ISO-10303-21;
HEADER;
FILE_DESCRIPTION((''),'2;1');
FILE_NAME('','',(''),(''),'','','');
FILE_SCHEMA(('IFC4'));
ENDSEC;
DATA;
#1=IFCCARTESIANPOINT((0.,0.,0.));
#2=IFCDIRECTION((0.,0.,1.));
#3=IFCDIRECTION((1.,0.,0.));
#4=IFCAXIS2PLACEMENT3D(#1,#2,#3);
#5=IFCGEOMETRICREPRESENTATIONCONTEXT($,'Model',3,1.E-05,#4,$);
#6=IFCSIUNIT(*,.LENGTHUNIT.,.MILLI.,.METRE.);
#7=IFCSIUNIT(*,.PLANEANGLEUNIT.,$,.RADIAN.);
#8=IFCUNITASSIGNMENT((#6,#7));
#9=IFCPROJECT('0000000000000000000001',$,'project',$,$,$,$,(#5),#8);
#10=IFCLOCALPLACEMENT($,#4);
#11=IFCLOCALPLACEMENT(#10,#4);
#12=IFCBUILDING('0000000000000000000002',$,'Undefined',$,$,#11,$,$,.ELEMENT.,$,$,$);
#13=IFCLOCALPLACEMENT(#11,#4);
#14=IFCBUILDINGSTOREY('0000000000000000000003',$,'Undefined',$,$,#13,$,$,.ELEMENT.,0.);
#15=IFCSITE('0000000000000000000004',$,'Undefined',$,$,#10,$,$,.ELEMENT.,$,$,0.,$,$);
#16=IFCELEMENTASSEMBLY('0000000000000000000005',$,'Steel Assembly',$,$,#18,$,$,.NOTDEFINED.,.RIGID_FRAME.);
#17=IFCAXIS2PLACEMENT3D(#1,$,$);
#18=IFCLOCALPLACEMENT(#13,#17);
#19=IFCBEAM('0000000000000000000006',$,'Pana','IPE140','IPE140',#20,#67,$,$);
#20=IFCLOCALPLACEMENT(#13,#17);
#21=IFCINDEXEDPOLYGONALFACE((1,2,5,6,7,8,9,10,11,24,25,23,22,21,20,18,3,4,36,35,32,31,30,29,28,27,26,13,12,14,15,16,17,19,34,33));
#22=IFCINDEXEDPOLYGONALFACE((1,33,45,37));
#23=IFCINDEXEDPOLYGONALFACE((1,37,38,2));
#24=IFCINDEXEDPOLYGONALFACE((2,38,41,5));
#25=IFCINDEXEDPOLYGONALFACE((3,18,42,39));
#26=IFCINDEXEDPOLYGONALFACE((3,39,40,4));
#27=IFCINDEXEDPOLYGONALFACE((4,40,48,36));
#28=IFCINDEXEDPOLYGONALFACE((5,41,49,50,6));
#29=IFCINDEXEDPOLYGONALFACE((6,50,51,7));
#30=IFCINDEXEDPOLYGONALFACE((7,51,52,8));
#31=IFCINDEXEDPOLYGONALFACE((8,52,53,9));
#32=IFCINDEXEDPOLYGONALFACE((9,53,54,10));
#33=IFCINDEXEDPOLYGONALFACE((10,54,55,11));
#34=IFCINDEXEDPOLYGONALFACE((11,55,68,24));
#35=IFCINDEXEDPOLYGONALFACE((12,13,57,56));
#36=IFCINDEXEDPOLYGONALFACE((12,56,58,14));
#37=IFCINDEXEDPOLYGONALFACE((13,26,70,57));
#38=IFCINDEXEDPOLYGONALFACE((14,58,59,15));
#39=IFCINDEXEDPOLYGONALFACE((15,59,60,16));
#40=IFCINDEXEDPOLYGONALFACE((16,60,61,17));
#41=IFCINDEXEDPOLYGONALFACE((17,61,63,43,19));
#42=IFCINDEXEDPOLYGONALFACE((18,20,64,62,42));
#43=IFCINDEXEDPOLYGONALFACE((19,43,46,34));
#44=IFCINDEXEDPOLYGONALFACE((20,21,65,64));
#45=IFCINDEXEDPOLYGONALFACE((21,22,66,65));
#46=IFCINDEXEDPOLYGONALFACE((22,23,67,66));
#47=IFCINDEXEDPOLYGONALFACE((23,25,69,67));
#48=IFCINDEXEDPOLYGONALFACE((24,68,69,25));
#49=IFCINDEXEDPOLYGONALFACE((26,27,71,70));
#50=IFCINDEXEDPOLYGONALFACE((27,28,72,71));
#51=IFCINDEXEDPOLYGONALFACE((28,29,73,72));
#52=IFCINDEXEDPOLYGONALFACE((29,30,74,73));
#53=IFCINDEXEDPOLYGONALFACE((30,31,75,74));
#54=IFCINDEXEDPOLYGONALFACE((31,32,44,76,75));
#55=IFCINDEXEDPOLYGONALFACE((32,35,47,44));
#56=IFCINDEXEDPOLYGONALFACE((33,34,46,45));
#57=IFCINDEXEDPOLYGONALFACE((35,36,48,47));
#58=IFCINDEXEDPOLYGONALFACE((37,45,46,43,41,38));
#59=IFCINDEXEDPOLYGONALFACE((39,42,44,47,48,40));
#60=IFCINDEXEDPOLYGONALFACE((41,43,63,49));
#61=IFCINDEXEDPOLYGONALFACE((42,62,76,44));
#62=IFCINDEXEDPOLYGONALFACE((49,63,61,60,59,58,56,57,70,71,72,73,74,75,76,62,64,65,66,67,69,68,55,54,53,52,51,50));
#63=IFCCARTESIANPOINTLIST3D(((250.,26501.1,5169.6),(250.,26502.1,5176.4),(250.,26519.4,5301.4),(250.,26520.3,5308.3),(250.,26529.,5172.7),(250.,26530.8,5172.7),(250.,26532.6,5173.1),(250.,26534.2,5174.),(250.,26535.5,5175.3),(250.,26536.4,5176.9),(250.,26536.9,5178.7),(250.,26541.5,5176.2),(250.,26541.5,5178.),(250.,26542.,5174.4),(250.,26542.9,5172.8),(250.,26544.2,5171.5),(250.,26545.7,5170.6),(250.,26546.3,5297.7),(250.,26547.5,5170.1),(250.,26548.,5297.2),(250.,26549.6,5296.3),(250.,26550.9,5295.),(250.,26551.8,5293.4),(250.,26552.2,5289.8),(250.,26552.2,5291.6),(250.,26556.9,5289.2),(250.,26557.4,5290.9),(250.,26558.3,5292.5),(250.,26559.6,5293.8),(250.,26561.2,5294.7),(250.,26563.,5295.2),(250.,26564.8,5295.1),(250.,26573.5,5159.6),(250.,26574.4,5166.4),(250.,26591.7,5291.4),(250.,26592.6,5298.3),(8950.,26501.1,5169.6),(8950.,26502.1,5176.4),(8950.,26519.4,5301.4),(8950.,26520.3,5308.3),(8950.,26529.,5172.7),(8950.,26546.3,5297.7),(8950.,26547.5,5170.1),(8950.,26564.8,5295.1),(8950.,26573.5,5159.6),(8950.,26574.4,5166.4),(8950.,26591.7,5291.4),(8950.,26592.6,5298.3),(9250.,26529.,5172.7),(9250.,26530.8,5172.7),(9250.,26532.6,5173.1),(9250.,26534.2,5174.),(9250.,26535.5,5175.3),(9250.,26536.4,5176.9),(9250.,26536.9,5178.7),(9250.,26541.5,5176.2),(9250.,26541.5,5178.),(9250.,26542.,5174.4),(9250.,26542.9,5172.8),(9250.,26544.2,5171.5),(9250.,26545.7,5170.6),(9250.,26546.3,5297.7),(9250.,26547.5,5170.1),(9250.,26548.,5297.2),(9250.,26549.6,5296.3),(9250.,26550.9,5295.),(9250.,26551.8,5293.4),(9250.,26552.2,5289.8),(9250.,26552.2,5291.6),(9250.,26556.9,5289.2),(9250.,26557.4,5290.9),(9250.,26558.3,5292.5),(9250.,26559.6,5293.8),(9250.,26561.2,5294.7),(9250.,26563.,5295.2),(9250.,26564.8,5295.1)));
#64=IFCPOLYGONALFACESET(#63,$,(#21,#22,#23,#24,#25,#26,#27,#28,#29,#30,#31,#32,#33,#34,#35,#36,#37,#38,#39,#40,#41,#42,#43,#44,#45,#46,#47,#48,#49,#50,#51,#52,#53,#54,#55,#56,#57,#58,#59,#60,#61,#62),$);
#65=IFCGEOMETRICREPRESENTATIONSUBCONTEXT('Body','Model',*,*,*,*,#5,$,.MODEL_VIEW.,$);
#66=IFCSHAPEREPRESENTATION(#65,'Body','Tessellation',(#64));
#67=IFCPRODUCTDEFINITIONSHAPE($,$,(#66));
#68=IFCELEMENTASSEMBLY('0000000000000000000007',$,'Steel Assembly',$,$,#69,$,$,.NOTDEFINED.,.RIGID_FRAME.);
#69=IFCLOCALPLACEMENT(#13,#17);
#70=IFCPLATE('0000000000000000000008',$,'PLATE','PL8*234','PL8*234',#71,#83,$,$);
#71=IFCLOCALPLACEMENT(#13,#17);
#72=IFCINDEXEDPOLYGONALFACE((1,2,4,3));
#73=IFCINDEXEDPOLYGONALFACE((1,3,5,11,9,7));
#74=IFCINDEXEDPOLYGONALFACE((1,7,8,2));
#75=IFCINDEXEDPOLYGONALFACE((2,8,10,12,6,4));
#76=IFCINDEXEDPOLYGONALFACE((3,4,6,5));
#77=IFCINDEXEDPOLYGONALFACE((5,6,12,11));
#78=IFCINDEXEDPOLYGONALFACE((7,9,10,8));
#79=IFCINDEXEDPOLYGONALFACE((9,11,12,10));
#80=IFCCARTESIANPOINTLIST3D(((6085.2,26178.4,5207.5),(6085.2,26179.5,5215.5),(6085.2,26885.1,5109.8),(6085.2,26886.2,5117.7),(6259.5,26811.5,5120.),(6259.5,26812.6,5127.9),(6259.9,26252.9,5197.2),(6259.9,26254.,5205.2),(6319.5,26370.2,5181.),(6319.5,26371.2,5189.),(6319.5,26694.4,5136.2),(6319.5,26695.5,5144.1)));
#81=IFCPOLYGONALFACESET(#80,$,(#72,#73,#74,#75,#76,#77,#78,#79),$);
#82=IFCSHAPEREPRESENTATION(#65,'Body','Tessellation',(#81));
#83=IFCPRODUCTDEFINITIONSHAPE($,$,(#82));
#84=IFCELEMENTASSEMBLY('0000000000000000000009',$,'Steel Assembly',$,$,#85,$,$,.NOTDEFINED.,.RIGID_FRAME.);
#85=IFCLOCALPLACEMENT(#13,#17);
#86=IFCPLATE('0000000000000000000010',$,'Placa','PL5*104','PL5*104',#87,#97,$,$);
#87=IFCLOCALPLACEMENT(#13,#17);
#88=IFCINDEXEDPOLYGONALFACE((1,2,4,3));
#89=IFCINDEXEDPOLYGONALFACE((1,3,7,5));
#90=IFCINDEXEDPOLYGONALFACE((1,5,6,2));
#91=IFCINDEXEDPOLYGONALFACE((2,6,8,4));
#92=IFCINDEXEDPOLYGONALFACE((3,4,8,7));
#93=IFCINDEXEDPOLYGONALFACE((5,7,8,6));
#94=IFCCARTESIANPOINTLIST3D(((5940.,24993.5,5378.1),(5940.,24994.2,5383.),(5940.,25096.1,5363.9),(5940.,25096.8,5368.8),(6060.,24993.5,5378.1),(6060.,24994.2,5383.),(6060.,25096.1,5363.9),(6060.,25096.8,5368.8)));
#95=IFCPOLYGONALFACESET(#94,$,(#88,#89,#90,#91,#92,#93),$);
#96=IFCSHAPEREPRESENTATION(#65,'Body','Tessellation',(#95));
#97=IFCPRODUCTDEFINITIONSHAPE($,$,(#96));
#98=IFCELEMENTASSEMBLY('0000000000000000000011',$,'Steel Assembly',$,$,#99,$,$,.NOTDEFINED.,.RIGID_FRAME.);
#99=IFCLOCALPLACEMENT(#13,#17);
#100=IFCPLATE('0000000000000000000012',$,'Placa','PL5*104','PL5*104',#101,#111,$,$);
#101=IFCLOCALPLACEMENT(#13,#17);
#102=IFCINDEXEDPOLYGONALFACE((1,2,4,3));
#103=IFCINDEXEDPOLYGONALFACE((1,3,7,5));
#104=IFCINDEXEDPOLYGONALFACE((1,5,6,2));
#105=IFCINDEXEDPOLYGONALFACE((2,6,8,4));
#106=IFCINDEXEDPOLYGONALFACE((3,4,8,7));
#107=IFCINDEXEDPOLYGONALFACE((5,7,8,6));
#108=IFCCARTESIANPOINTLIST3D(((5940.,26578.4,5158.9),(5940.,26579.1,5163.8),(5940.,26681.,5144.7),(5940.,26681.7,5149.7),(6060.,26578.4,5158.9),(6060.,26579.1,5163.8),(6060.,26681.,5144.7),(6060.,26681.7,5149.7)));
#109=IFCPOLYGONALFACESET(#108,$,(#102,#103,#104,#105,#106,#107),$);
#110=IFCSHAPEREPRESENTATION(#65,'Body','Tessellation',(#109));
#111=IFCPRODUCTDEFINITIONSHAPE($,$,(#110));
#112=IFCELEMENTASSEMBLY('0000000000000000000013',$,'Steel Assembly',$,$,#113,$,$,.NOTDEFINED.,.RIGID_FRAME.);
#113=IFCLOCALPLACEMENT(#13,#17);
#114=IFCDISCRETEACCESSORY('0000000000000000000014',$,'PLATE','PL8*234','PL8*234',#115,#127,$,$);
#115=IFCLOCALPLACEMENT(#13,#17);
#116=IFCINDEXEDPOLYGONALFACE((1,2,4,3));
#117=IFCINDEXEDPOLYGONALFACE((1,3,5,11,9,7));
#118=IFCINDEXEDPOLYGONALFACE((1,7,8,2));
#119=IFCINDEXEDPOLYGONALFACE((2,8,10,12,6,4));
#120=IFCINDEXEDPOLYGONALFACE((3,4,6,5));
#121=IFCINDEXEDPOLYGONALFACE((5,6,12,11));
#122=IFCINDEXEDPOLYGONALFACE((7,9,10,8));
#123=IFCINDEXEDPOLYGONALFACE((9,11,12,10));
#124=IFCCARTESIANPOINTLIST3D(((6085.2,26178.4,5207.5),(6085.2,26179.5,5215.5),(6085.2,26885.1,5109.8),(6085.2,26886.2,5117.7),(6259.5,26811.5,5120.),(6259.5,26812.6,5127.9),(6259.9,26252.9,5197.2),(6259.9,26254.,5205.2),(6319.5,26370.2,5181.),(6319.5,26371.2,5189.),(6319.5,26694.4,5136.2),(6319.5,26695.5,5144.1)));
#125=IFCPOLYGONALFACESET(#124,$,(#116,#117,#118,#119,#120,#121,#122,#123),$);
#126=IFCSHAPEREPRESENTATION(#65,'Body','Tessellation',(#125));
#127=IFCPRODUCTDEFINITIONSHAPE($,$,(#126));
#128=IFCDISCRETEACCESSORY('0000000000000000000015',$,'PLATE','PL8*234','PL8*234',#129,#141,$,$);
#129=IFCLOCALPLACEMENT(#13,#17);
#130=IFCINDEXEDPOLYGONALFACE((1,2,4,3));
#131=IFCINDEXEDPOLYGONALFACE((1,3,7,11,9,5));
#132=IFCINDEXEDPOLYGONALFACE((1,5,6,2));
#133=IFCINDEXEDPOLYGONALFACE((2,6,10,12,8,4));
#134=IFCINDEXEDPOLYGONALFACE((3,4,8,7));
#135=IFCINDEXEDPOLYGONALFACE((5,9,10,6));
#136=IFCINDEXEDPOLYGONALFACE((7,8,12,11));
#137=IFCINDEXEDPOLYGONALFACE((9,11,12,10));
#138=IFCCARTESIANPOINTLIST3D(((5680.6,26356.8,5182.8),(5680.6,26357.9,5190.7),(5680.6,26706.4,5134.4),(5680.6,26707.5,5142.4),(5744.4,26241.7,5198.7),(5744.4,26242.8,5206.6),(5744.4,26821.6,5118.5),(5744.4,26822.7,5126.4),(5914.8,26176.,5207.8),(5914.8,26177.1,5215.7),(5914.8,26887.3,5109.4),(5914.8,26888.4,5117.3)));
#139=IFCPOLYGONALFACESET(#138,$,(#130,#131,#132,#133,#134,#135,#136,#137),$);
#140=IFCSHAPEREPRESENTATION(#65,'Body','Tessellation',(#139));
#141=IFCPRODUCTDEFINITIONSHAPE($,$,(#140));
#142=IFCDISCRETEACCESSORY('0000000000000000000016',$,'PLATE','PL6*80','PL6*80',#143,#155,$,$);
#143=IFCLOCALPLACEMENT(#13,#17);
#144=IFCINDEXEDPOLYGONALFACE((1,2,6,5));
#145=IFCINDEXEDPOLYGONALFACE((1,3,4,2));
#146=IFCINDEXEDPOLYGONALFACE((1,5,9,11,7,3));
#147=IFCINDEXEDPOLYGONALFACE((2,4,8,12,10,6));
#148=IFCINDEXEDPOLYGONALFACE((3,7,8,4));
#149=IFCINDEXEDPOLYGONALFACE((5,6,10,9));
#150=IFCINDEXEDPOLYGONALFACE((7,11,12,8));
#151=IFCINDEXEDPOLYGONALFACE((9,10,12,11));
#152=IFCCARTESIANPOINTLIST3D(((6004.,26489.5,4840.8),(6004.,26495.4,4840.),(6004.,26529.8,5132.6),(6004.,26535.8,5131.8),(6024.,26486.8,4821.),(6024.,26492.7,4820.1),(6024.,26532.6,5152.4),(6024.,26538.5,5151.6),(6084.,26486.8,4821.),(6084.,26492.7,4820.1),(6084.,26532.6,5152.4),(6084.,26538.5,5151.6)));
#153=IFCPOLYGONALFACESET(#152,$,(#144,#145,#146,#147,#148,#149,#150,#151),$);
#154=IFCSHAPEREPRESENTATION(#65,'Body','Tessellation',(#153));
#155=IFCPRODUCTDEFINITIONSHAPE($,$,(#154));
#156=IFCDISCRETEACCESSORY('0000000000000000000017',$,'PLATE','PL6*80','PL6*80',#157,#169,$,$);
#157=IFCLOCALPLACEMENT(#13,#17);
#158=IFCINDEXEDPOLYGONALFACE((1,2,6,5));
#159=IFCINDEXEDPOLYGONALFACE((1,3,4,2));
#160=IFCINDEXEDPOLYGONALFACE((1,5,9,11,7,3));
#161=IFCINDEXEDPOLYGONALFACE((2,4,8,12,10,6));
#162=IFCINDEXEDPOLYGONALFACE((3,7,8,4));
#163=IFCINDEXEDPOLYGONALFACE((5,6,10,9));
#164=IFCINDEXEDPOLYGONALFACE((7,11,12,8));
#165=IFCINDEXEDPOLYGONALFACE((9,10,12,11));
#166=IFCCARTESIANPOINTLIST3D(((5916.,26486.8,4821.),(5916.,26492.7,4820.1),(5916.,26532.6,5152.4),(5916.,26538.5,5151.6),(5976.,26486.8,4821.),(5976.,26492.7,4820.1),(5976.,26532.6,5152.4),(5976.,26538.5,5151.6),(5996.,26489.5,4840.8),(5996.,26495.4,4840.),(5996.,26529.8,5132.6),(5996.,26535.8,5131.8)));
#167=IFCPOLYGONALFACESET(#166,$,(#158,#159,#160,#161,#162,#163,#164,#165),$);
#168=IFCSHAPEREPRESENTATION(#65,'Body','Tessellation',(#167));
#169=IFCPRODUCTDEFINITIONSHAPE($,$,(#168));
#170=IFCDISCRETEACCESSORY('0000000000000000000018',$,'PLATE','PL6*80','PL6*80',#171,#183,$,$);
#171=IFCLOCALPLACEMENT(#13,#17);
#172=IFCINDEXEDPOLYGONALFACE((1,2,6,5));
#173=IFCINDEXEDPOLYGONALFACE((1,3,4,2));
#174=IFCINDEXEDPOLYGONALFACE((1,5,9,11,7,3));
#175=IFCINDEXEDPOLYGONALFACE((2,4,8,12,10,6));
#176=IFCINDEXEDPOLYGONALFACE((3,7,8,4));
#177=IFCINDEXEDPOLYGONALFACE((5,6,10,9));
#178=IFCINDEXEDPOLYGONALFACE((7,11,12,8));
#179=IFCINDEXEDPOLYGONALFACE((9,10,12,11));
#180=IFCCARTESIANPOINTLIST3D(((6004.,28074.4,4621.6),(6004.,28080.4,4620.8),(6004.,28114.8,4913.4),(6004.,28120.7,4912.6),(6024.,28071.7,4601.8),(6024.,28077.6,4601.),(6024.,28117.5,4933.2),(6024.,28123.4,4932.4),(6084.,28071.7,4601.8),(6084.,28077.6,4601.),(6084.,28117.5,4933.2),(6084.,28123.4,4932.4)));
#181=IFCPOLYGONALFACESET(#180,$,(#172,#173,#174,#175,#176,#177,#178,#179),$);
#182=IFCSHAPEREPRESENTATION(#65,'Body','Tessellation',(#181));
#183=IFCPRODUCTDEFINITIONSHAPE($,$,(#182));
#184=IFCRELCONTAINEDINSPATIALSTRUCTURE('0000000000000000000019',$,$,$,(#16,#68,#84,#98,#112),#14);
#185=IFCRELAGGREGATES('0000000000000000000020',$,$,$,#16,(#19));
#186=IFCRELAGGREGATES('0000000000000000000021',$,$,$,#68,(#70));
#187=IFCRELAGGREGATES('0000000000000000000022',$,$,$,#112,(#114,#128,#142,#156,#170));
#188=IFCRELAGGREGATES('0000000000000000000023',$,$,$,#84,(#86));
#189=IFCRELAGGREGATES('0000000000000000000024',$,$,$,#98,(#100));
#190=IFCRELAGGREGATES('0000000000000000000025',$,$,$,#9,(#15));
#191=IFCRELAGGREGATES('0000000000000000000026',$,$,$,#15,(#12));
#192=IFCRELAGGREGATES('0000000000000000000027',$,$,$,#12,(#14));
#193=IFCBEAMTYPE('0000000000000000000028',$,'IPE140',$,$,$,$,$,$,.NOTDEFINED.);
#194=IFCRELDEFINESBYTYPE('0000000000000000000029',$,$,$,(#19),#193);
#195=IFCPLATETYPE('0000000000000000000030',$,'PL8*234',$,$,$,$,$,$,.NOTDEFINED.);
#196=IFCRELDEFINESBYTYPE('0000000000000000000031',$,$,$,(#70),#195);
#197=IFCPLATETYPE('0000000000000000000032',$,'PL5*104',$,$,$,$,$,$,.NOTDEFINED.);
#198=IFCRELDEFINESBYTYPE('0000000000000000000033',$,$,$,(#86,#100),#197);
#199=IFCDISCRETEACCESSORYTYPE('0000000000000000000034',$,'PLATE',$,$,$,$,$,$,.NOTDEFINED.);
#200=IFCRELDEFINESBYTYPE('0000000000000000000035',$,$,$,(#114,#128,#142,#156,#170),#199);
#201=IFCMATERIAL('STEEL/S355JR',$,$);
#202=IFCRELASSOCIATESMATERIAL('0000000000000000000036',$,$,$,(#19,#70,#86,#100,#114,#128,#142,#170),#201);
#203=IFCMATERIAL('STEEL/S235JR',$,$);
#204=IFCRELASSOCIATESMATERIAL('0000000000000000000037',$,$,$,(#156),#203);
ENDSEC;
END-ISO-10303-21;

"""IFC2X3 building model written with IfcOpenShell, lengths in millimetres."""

from ifc_helpers import new_model, si_unit, frame, origin_with_axes, origin_2d_with_axis, place, context, subcontext, project, spatial, polyline, i_section, outline, extrude, boolean, halfspace, material, type_object, element, aggregate, save


model = new_model("IFC2X3")

# Units and contexts
model_context = context("Model", 3, precision=1e-05, world=origin_with_axes())
body_context = subcontext(model_context, "Body", "Model", "MODEL_VIEW")
ifc_project = project(units=[si_unit("LENGTHUNIT", "METRE", prefix="MILLI"), si_unit("PLANEANGLEUNIT", "RADIAN")], contexts=[model_context])

# Site, building, storey
site_placement = place(None, origin_with_axes())
site = spatial("IfcSite", under=ifc_project, at=site_placement, Name="Undefined", CompositionType="ELEMENT", RefElevation=0.0)
building_placement = place(site_placement, origin_with_axes())
building = spatial("IfcBuilding", under=site, at=building_placement, Name="Undefined", CompositionType="ELEMENT")
storey_placement = place(building_placement, origin_with_axes())
storey = spatial("IfcBuildingStorey", under=building, at=storey_placement, Name="Undefined", CompositionType="ELEMENT", Elevation=0.0)

# Element assembly, beam
ifc_material_1 = material(Name="STEEL/S355JR")
beam_type_1 = type_object("IfcBeamType", Name="IPE140", PredefinedType="NOTDEFINED")
assembly_1_placement = place(storey_placement, origin_with_axes())
assembly_1 = element("IfcElementAssembly", 1, at=assembly_1_placement, inside=storey, Name="Steel Assembly", AssemblyPlace="NOTDEFINED", PredefinedType="RIGID_FRAME")
beam_1_placement = place(assembly_1_placement, frame((9250.0, 26546.9, 5233.9), z_axis=(0.0, 0.136926, 0.990581), x_axis=(-1.0, 0.0, 0.0)))
beam_1 = element("IfcBeam", 2, at=beam_1_placement, type_object=beam_type_1, material=ifc_material_1, Name="Pana", Description="IPE140", ObjectType="IPE140", context=body_context, shape_type="CSG", body=[
    boolean("DIFFERENCE", boolean("DIFFERENCE", extrude(i_section(OverallWidth=73.0, OverallDepth=140.0, WebThickness=4.7, FlangeThickness=6.9, FilletRadius=7.0, at=origin_2d_with_axis()), frame((9000.0, 0.0, 0.0), z_axis=(-1.0, 0.0, 0.0), x_axis=(0.0, -1.0, 0.0)), (0.0, 0.0, 1.0), 9005.0), extrude(outline(polyline([(0.0, 0.0), (11.9, 0.0), (11.9, 300.0), (138.1, 300.0), (138.1, 0.0), (150.0, 0.0), (150.0, 305.0), (0.0, 305.0), (0.0, 0.0)])), frame((300.0, -41.5, 75.0), z_axis=(0.0, 1.0, 0.0), x_axis=(0.0, 0.0, -1.0)), (0.0, 0.0, 1.0), 83.0)), halfspace(frame((-5.0, 0.0, 1070.0), z_axis=(1.0, 0.0, 0.0), x_axis=(0.0, 0.0, -1.0)), True)),
])
aggregate(assembly_1, [beam_1])

# Element assemblies, plates
assembly_2_placement = place(storey_placement, origin_with_axes())
assembly_2 = element("IfcElementAssembly", 3, at=assembly_2_placement, inside=storey, Name="Steel Assembly", AssemblyPlace="NOTDEFINED", PredefinedType="RIGID_FRAME")
plate_type_1 = type_object("IfcPlateType", Name="PL8*234", PredefinedType="NOTDEFINED")
plate_1_placement = place(assembly_2_placement, frame((6085.2, 26885.7, 5113.8), z_axis=(-0.000018, 0.13698, 0.990574), x_axis=(0.0, -0.990574, 0.13698)))
plate_1 = element("IfcPlate", 4, at=plate_1_placement, type_object=plate_type_1, material=ifc_material_1, Name="PLATE", Description="PL8*234", ObjectType="PL8*234", context=body_context, shape_type="SweptSolid", body=[
    extrude(outline(polyline([(0.0, 0.0), (713.5, 0.0), (638.3, 174.6), (519.9, 234.3), (192.5, 234.3), (74.3, 174.2), (0.0, 0.0)])), frame((0.0, 0.0, -4.0), z_axis=(0.0, 0.0, 1.0), x_axis=(1.0, 0.0, 0.0)), (0.0, 0.0, 1.0), 8.0),
])
aggregate(assembly_2, [plate_1])
assembly_3_placement = place(storey_placement, origin_with_axes())
assembly_3 = element("IfcElementAssembly", 5, at=assembly_3_placement, inside=storey, Name="Steel Assembly", AssemblyPlace="NOTDEFINED", PredefinedType="RIGID_FRAME")
plate_type_2 = type_object("IfcPlateType", Name="PL5*104", PredefinedType="NOTDEFINED")
plate_2_placement = place(assembly_3_placement, frame((5940.0, 24993.8, 5380.5), z_axis=(0.0, -0.136905, -0.990584), x_axis=(0.0, 0.990584, -0.136905)))
plate_2 = element("IfcPlate", 6, at=plate_2_placement, type_object=plate_type_2, material=ifc_material_1, Name="Placa", Description="PL5*104", ObjectType="PL5*104", context=body_context, shape_type="SweptSolid", body=[
    extrude(outline(polyline([(0.0, 0.0), (103.6, 0.0), (103.6, 120.0), (0.0, 120.0), (0.0, 0.0)])), frame((0.0, 0.0, -2.5), z_axis=(0.0, 0.0, 1.0), x_axis=(1.0, 0.0, 0.0)), (0.0, 0.0, 1.0), 5.0),
])
assembly_4_placement = place(storey_placement, origin_with_axes())
assembly_4 = element("IfcElementAssembly", 7, at=assembly_4_placement, inside=storey, Name="Steel Assembly", AssemblyPlace="NOTDEFINED", PredefinedType="RIGID_FRAME")
plate_3_placement = place(assembly_4_placement, frame((5940.0, 26578.7, 5161.4), z_axis=(0.0, -0.136905, -0.990584), x_axis=(0.0, 0.990584, -0.136905)))
plate_3 = element("IfcPlate", 8, at=plate_3_placement, type_object=plate_type_2, material=ifc_material_1, Name="Placa", Description="PL5*104", ObjectType="PL5*104", context=body_context, shape_type="SweptSolid", body=[
    extrude(outline(polyline([(0.0, 0.0), (103.6, 0.0), (103.6, 120.0), (0.0, 120.0), (0.0, 0.0)])), frame((0.0, 0.0, -2.5), z_axis=(0.0, 0.0, 1.0), x_axis=(1.0, 0.0, 0.0)), (0.0, 0.0, 1.0), 5.0),
])

# Element assembly, discrete accessories
assembly_5_placement = place(storey_placement, origin_with_axes())
assembly_5 = element("IfcElementAssembly", 9, at=assembly_5_placement, inside=storey, Name="Steel Assembly", AssemblyPlace="NOTDEFINED", PredefinedType="RIGID_FRAME")
discrete_accessory_type_1 = type_object("IfcDiscreteAccessoryType", Name="PLATE")
discrete_accessory_1_placement = place(assembly_5_placement, frame((6085.2, 26885.7, 5113.8), z_axis=(-0.000018, 0.13698, 0.990574), x_axis=(0.0, -0.990574, 0.13698)))
discrete_accessory_1 = element("IfcDiscreteAccessory", 10, at=discrete_accessory_1_placement, type_object=discrete_accessory_type_1, material=ifc_material_1, Name="PLATE", Description="PL8*234", ObjectType="PL8*234", context=body_context, shape_type="SweptSolid", body=[
    extrude(outline(polyline([(0.0, 0.0), (713.5, 0.0), (638.3, 174.6), (519.9, 234.3), (192.5, 234.3), (74.3, 174.2), (0.0, 0.0)])), frame((0.0, 0.0, -4.0), z_axis=(0.0, 0.0, 1.0), x_axis=(1.0, 0.0, 0.0)), (0.0, 0.0, 1.0), 8.0),
])
discrete_accessory_2_placement = place(assembly_5_placement, frame((5914.8, 26176.5, 5211.7), z_axis=(0.0, 0.13698, 0.990574), x_axis=(0.0, 0.990574, -0.13698)))
discrete_accessory_2 = element("IfcDiscreteAccessory", 11, at=discrete_accessory_2_placement, type_object=discrete_accessory_type_1, material=ifc_material_1, Name="PLATE", Description="PL8*234", ObjectType="PL8*234", context=body_context, shape_type="SweptSolid", body=[
    extrude(outline(polyline([(0.0, 0.0), (718.0, 0.0), (651.7, 170.3), (535.5, 234.1), (182.5, 234.1), (66.3, 170.3), (0.0, 0.0)])), frame((0.0, 0.0, -4.0), z_axis=(0.0, 0.0, 1.0), x_axis=(1.0, 0.0, 0.0)), (0.0, 0.0, 1.0), 8.0),
])
discrete_accessory_3_placement = place(assembly_5_placement, frame((6084.0, 26489.7, 4820.6), z_axis=(0.0, 0.990574, -0.13698), x_axis=(-1.0, 0.0, 0.0)))
discrete_accessory_3 = element("IfcDiscreteAccessory", 12, at=discrete_accessory_3_placement, type_object=discrete_accessory_type_1, material=ifc_material_1, Name="PLATE", Description="PL6*80", ObjectType="PL6*80", context=body_context, shape_type="SweptSolid", body=[
    extrude(outline(polyline([(0.0, 0.0), (60.0, 0.0), (80.0, 20.0), (80.0, 314.6), (60.0, 334.6), (0.0, 334.6), (0.0, 0.0)])), frame((0.0, 0.0, -3.0), z_axis=(0.0, 0.0, 1.0), x_axis=(1.0, 0.0, 0.0)), (0.0, 0.0, 1.0), 6.0),
])
ifc_material_2 = material(Name="STEEL/S235JR")
discrete_accessory_4_placement = place(assembly_5_placement, frame((5996.0, 26489.7, 4820.6), z_axis=(0.0, 0.990574, -0.13698), x_axis=(-1.0, 0.0, 0.0)))
discrete_accessory_4 = element("IfcDiscreteAccessory", 13, at=discrete_accessory_4_placement, type_object=discrete_accessory_type_1, material=ifc_material_2, Name="PLATE", Description="PL6*80", ObjectType="PL6*80", context=body_context, shape_type="SweptSolid", body=[
    extrude(outline(polyline([(0.0, 20.0), (20.0, 0.0), (80.0, 0.0), (80.0, 334.6), (20.0, 334.6), (0.0, 314.6), (0.0, 20.0)])), frame((0.0, 0.0, -3.0), z_axis=(0.0, 0.0, 1.0), x_axis=(1.0, 0.0, 0.0)), (0.0, 0.0, 1.0), 6.0),
])
discrete_accessory_5_placement = place(assembly_5_placement, frame((6084.0, 28074.6, 4601.4), z_axis=(0.0, 0.990574, -0.13698), x_axis=(-1.0, 0.0, 0.0)))
discrete_accessory_5 = element("IfcDiscreteAccessory", 14, at=discrete_accessory_5_placement, type_object=discrete_accessory_type_1, material=ifc_material_1, Name="PLATE", Description="PL6*80", ObjectType="PL6*80", context=body_context, shape_type="SweptSolid", body=[
    extrude(outline(polyline([(0.0, 0.0), (60.0, 0.0), (80.0, 20.0), (80.0, 314.6), (60.0, 334.6), (0.0, 334.6), (0.0, 0.0)])), frame((0.0, 0.0, -3.0), z_axis=(0.0, 0.0, 1.0), x_axis=(1.0, 0.0, 0.0)), (0.0, 0.0, 1.0), 6.0),
])
aggregate(assembly_5, [discrete_accessory_1, discrete_accessory_2, discrete_accessory_3, discrete_accessory_4, discrete_accessory_5])

aggregate(assembly_3, [plate_2])
aggregate(assembly_4, [plate_3])

save(model, "model.ifc")
